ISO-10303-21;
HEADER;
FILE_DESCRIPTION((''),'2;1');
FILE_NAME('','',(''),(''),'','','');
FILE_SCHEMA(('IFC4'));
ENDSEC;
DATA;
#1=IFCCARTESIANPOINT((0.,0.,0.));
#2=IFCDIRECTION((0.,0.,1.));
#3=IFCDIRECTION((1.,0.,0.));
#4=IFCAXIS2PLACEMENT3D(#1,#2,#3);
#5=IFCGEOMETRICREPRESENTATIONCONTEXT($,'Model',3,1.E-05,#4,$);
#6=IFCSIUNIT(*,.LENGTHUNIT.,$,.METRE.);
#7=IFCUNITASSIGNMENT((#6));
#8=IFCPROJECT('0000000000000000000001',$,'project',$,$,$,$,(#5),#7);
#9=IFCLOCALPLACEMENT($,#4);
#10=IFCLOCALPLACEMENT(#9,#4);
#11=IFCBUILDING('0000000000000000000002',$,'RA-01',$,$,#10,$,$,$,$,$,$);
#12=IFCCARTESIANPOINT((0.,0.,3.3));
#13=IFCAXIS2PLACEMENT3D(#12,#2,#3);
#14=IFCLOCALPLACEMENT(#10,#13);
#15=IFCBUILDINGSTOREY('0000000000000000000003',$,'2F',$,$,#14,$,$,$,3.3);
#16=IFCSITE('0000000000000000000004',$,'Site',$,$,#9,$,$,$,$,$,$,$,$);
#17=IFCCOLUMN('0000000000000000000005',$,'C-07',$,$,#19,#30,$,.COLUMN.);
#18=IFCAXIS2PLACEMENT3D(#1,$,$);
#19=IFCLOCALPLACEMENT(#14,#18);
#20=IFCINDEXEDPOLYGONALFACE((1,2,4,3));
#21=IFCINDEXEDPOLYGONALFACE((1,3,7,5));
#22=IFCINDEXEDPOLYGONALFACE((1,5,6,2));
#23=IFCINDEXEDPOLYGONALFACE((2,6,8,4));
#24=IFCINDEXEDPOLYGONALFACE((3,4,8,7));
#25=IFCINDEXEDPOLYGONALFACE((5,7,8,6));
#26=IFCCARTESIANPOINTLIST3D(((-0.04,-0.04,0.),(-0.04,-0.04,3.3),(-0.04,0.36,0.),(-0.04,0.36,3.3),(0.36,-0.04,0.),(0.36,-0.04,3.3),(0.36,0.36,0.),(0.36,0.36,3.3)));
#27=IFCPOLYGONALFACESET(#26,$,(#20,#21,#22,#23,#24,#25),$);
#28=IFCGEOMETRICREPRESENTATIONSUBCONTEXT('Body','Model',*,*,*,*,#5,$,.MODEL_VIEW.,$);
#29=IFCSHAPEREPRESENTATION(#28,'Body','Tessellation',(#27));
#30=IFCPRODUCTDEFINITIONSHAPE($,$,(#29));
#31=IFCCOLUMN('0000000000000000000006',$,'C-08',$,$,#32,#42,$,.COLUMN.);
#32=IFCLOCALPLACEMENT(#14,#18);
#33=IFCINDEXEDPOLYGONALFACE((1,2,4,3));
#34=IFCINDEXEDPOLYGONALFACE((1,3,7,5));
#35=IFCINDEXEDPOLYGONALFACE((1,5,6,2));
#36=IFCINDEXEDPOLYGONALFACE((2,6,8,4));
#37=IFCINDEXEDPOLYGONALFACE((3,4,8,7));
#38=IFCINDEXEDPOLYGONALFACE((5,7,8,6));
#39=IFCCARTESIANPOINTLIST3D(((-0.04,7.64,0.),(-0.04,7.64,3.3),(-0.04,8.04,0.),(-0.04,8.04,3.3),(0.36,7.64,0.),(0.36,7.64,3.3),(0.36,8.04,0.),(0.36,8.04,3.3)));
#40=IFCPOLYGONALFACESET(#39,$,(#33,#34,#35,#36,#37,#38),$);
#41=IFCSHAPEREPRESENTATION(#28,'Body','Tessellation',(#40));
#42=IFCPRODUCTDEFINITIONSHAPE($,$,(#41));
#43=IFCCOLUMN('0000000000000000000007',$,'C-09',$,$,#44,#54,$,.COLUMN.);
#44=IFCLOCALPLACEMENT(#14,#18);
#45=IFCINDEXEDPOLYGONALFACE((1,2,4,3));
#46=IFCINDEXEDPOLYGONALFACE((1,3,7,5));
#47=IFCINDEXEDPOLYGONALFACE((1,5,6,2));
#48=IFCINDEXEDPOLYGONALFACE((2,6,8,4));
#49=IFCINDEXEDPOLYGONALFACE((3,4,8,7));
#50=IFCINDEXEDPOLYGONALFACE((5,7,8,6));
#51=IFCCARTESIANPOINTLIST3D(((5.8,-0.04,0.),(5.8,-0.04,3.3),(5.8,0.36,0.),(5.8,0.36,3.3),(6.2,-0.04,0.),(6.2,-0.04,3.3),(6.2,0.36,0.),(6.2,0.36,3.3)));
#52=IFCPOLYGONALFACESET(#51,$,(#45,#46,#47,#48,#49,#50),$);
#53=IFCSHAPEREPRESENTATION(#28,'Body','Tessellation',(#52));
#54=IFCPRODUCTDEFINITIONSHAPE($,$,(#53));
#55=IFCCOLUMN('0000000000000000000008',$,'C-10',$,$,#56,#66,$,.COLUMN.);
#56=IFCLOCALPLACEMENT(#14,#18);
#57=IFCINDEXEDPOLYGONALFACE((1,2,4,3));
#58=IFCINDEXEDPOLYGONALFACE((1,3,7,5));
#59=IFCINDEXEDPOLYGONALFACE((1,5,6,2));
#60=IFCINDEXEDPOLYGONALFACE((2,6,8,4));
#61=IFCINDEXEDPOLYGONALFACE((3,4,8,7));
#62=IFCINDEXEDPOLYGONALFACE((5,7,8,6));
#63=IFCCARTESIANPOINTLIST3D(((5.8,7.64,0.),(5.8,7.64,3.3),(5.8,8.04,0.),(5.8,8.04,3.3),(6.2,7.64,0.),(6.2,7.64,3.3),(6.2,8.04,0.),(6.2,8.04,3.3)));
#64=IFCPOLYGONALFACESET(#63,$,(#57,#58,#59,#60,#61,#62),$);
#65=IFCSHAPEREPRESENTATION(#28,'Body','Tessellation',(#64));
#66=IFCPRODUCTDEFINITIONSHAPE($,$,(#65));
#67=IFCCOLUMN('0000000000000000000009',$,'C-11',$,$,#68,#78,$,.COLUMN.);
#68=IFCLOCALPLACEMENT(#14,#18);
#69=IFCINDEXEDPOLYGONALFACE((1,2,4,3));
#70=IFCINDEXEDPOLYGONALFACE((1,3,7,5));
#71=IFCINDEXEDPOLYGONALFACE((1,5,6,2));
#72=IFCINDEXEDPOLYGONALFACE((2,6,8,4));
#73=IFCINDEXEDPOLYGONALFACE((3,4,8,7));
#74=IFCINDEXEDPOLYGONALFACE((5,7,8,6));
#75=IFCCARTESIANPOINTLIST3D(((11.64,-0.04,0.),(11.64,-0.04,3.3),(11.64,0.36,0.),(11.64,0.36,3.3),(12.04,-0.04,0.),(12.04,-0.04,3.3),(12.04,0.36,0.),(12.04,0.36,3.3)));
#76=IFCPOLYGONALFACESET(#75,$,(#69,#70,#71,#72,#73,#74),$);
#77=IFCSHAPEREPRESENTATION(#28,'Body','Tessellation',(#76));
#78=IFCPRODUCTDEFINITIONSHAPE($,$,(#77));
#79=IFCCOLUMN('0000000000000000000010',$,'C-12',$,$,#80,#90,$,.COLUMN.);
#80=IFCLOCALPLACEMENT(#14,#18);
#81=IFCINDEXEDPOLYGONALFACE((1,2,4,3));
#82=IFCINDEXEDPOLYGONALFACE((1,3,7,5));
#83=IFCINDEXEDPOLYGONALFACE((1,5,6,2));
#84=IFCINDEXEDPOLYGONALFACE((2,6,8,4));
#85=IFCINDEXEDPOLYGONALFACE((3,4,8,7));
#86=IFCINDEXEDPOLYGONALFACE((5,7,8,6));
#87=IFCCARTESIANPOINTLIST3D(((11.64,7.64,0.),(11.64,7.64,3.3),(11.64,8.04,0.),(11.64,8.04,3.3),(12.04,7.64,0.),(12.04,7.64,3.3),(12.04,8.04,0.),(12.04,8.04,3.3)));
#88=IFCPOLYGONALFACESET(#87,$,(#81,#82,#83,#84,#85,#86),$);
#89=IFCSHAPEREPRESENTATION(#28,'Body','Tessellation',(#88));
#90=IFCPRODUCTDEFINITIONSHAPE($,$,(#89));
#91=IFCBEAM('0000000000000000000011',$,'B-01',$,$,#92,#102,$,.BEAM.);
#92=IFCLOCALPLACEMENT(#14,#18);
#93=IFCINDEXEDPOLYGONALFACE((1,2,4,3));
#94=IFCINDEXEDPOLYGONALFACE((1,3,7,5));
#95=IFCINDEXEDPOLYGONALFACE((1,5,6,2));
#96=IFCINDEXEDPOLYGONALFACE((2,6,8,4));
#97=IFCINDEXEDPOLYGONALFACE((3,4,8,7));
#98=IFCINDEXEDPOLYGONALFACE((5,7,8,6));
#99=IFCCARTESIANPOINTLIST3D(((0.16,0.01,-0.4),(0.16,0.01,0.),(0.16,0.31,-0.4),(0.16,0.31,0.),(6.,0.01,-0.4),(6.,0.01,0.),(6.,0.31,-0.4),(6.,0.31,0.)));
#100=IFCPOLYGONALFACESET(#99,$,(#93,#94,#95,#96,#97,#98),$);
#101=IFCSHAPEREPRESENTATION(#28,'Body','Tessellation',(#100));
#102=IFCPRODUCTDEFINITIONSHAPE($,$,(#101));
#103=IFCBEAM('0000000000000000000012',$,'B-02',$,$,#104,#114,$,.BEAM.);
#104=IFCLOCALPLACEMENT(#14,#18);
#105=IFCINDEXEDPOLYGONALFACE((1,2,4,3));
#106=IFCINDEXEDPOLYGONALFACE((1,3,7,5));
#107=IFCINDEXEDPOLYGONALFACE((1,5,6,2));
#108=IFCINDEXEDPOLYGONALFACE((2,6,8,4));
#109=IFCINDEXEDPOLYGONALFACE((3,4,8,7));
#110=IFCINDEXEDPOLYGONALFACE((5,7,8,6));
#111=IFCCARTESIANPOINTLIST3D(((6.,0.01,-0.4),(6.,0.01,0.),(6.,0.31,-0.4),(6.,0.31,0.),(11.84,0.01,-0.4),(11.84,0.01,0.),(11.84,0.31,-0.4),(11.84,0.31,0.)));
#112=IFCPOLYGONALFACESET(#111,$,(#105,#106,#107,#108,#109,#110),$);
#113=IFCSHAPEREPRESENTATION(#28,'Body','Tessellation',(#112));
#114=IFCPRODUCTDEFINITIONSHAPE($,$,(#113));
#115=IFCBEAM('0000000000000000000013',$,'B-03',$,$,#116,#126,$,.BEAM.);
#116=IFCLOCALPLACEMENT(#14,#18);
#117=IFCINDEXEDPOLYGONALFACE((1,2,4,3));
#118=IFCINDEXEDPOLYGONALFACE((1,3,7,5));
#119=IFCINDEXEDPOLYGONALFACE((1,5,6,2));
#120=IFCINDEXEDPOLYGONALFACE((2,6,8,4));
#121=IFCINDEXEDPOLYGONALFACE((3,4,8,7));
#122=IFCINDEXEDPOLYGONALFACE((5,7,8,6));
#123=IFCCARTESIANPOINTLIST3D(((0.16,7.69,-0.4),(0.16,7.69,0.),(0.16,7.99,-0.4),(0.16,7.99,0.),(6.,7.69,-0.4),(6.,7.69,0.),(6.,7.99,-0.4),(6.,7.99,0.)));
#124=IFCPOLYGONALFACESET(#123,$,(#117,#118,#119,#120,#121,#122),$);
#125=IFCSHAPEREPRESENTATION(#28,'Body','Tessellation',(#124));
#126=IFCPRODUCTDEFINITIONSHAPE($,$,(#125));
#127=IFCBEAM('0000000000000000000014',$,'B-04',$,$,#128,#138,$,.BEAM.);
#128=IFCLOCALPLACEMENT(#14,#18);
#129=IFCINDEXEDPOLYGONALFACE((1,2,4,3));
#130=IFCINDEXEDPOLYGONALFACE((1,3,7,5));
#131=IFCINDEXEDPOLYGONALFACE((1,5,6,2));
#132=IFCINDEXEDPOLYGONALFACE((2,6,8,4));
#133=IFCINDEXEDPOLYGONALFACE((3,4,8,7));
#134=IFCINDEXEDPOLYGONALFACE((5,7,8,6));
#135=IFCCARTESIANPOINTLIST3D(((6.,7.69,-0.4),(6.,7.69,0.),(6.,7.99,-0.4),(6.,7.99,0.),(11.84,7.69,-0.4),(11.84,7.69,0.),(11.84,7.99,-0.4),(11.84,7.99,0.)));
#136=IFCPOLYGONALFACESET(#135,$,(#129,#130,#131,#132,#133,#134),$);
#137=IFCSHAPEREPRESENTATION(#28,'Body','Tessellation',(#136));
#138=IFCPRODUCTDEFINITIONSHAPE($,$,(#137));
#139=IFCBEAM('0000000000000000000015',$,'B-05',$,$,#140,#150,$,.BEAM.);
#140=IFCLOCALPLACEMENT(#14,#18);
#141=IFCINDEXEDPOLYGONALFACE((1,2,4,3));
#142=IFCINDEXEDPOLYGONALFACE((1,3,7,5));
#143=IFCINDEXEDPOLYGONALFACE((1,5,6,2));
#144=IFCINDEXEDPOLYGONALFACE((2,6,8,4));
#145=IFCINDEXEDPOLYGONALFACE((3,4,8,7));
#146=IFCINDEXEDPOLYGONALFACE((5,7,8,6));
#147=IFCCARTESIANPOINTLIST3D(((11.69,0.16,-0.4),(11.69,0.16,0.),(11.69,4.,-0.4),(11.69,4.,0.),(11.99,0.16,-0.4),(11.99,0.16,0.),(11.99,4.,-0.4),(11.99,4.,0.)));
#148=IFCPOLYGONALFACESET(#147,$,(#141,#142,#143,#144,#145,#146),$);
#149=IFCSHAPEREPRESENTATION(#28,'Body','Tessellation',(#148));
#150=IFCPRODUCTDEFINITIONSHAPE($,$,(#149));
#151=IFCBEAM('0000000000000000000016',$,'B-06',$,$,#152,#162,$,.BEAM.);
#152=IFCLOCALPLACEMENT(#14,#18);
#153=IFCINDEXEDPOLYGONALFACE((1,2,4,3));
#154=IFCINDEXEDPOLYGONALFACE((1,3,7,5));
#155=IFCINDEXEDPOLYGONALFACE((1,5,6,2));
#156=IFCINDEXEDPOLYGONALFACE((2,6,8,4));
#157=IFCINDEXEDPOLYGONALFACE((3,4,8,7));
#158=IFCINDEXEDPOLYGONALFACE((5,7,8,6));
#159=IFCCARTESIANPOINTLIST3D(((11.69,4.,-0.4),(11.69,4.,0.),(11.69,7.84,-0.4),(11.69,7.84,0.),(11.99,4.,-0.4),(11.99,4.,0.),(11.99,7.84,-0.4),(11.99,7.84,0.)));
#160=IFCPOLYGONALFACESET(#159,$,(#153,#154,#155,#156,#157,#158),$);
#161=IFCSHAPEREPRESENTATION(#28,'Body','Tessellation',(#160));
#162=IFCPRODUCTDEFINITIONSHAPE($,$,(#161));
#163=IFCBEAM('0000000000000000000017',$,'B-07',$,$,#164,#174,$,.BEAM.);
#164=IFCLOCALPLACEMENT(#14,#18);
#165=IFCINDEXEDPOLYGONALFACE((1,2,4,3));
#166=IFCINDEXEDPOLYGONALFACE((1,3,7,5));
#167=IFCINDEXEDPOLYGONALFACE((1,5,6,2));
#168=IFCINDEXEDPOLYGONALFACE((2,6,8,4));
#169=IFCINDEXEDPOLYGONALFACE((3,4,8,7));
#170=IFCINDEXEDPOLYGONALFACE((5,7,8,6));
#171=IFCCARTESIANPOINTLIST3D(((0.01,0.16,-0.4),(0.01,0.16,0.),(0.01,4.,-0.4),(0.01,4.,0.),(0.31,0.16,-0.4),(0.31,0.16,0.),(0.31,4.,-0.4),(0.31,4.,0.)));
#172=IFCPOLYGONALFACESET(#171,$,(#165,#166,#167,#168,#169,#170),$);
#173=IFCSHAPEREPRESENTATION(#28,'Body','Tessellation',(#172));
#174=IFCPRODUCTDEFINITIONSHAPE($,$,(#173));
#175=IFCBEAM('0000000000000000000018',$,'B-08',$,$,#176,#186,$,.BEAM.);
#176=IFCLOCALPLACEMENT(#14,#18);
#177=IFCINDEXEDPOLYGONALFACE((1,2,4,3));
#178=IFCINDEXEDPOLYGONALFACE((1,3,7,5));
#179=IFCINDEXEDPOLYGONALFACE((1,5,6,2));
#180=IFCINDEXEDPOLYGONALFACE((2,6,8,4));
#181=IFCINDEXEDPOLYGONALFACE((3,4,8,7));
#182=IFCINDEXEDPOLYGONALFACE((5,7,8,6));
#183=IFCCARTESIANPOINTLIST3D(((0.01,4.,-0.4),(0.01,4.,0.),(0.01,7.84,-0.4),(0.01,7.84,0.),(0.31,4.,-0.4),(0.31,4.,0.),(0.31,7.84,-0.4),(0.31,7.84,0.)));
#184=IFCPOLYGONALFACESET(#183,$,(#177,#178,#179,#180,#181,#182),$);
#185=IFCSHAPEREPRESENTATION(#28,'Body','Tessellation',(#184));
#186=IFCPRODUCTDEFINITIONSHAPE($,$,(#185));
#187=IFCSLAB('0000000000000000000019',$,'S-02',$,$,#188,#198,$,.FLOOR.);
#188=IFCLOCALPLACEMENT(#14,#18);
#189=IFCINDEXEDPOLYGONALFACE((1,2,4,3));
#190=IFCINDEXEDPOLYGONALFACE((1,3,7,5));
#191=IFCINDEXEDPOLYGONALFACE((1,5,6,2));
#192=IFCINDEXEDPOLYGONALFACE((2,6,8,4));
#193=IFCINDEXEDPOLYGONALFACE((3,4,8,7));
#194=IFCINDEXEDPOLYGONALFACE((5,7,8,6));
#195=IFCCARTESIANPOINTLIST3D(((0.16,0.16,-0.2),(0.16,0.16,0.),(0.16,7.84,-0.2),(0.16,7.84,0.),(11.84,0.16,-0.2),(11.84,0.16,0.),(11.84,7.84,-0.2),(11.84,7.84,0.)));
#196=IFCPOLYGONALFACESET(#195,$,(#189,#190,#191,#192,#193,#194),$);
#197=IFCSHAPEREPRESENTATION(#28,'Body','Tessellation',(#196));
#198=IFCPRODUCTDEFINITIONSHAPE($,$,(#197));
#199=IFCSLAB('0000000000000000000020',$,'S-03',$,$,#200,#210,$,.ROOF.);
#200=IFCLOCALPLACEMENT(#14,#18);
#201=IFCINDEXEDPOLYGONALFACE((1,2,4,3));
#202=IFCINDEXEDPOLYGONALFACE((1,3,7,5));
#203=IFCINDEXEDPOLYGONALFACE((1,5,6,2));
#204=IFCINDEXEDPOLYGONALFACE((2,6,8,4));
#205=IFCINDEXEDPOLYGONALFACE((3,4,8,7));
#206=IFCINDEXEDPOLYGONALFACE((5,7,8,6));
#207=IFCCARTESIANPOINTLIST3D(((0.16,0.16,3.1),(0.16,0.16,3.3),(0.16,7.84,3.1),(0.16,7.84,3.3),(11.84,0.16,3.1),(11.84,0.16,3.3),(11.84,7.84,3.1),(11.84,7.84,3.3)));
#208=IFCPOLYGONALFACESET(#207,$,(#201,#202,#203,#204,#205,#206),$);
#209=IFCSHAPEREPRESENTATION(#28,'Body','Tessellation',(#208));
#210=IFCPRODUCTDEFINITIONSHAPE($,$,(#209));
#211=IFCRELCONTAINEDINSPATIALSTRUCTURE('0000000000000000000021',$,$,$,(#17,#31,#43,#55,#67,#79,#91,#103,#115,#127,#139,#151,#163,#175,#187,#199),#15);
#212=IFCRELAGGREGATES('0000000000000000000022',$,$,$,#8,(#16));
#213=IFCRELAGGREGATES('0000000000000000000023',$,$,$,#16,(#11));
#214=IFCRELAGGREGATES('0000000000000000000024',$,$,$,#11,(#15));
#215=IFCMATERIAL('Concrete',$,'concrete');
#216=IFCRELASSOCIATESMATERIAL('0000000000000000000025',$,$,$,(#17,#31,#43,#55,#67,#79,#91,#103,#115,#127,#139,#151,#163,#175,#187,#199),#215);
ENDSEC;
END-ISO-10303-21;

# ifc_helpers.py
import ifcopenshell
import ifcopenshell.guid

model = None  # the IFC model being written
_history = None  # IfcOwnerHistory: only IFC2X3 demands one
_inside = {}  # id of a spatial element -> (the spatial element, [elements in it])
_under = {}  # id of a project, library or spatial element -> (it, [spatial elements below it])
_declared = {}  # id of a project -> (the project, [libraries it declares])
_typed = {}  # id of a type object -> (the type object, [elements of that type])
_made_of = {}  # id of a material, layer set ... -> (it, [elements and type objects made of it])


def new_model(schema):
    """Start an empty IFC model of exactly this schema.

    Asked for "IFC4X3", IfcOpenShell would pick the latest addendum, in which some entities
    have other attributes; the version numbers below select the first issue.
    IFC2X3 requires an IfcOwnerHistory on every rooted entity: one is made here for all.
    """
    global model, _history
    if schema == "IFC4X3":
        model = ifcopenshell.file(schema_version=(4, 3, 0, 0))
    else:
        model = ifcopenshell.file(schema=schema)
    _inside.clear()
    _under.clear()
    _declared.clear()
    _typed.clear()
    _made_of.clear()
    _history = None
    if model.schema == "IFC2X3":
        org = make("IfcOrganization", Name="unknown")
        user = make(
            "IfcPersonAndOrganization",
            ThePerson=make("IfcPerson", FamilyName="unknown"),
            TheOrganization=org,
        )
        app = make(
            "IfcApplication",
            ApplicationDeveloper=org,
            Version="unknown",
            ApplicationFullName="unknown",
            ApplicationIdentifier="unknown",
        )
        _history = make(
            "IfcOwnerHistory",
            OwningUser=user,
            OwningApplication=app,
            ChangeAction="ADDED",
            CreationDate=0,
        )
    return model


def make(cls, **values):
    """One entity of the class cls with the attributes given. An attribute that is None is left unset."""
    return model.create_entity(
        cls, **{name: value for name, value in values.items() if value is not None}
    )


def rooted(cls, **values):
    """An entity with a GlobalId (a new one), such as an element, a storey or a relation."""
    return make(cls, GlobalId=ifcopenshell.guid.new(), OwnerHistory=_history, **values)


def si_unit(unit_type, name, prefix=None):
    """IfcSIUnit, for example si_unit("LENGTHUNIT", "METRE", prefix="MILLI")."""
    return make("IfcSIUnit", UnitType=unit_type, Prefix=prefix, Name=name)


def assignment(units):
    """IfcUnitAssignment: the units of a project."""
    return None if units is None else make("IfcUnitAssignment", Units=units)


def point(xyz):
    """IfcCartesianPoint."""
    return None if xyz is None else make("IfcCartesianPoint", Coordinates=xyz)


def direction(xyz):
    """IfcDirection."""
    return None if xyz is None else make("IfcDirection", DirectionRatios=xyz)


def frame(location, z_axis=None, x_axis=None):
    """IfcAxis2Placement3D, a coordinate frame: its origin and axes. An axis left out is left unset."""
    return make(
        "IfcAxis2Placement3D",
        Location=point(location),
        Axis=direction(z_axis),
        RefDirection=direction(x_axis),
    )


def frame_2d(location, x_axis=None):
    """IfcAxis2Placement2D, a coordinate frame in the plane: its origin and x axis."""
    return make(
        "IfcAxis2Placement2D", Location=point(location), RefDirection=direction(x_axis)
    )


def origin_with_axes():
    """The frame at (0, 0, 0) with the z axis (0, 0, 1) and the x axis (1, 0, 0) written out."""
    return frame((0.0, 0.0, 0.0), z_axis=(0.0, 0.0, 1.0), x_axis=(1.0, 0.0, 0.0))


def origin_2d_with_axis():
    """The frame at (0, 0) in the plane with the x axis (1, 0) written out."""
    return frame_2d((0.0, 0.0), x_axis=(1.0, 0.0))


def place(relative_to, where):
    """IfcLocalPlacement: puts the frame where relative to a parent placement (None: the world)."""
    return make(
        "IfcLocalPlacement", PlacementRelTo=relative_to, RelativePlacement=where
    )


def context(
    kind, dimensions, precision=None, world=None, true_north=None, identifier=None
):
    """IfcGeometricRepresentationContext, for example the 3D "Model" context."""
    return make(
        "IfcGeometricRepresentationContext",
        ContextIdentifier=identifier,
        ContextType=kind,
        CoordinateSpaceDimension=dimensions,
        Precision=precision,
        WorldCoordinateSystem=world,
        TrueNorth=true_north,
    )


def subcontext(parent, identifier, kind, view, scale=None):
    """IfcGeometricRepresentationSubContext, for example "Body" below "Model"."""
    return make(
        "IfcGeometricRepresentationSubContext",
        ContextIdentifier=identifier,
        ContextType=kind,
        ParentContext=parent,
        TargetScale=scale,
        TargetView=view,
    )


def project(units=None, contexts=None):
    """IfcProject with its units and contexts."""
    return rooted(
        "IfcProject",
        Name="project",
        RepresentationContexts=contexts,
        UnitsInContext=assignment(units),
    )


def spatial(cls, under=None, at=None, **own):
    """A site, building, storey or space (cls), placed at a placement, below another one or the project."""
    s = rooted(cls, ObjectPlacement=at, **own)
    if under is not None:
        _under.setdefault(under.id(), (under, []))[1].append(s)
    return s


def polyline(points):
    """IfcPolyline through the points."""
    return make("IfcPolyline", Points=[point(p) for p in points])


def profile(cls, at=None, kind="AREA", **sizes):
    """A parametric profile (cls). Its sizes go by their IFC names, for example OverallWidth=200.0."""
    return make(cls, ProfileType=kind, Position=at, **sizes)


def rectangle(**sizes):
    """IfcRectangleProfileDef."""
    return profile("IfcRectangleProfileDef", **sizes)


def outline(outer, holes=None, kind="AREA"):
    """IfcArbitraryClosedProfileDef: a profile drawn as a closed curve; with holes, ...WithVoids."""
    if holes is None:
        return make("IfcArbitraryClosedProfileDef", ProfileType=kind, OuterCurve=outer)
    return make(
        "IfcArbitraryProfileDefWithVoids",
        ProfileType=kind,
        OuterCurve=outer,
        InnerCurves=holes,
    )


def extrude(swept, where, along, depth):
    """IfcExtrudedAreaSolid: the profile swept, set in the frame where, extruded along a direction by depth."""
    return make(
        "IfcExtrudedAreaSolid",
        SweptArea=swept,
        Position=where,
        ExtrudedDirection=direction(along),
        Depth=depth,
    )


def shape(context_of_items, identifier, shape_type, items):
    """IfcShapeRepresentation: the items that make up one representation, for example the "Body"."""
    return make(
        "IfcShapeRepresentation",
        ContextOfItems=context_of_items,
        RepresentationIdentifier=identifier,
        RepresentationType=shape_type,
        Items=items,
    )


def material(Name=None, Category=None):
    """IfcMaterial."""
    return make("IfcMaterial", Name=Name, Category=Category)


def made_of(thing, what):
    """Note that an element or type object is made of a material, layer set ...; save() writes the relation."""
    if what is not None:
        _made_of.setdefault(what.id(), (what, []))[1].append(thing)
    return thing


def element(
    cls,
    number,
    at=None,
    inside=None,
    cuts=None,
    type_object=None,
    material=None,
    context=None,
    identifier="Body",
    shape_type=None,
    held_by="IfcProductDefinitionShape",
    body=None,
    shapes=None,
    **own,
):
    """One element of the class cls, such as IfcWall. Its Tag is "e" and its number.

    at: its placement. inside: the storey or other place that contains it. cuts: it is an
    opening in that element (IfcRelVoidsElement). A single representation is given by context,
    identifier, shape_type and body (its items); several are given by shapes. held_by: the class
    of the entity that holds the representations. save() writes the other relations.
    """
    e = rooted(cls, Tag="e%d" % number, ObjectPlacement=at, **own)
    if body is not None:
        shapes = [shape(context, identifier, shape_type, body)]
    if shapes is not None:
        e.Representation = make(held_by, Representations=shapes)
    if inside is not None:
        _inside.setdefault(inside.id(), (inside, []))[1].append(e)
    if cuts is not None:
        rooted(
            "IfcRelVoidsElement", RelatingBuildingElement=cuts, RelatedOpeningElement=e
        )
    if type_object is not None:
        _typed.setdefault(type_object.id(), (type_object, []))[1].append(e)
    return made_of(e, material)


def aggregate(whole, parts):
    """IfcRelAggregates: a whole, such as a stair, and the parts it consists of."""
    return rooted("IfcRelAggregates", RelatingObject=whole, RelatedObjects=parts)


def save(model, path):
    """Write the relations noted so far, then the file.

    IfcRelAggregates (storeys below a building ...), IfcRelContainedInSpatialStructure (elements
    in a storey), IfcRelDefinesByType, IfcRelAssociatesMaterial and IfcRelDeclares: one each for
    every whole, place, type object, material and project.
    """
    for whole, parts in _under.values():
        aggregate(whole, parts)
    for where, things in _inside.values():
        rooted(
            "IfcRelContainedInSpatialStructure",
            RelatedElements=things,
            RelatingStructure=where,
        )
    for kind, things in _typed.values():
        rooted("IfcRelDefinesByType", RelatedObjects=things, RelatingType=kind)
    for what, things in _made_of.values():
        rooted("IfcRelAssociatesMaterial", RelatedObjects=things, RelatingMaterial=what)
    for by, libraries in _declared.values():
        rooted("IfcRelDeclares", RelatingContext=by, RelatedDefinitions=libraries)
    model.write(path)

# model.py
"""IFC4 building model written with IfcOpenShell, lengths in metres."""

from ifc_helpers import new_model, si_unit, frame, origin_with_axes, origin_2d_with_axis, place, context, subcontext, project, spatial, polyline, rectangle, outline, extrude, material, element, save


model = new_model("IFC4")

# Units and contexts
model_context = context("Model", 3, precision=1e-05, world=origin_with_axes())
body_context = subcontext(model_context, "Body", "Model", "MODEL_VIEW")
ifc_project = project(units=[si_unit("LENGTHUNIT", "METRE")], contexts=[model_context])

# Site, building, storey
site_placement = place(None, origin_with_axes())
site = spatial("IfcSite", under=ifc_project, at=site_placement, Name="Site")
building_placement = place(site_placement, origin_with_axes())
building = spatial("IfcBuilding", under=site, at=building_placement, Name="RA-01")
storey_placement = place(building_placement, frame((0.0, 0.0, 3.3), z_axis=(0.0, 0.0, 1.0), x_axis=(1.0, 0.0, 0.0)))
storey = spatial("IfcBuildingStorey", under=building, at=storey_placement, Name="2F", Elevation=3.3)

# Columns
ifc_material_1 = material(Name="Concrete", Category="concrete")
for number, where, z_axis, x_axis, name in (
    (1, (0.16, 0.16, 0.0), (0.0, 0.0, 1.0), (1.0, 0.0, 0.0), "C-07"),
    (2, (0.16, 7.84, 0.0), (0.0, 0.0, 1.0), (1.0, 0.0, 0.0), "C-08"),
    (3, (6.0, 0.16, 0.0), (0.0, 0.0, 1.0), (1.0, 0.0, 0.0), "C-09"),
    (4, (6.0, 7.84, 0.0), (0.0, 0.0, 1.0), (1.0, 0.0, 0.0), "C-10"),
    (5, (11.84, 0.16, 0.0), (0.0, 0.0, 1.0), (1.0, 0.0, 0.0), "C-11"),
    (6, (11.84, 7.84, 0.0), (0.0, 0.0, 1.0), (1.0, 0.0, 0.0), "C-12"),
):
    element("IfcColumn", number, at=place(storey_placement, frame(where, z_axis=z_axis, x_axis=x_axis)), inside=storey, material=ifc_material_1, Name=name, PredefinedType="COLUMN", context=body_context, shape_type="SweptSolid", body=[
        extrude(rectangle(XDim=0.4, YDim=0.4, at=origin_2d_with_axis()), origin_with_axes(), (0.0, 0.0, 1.0), 3.3),
    ])

# Beams
for number, where, z_axis, x_axis, name in (
    (7, (0.16, 0.16, -0.2), (1.0, 0.0, 0.0), (0.0, 1.0, 0.0), "B-01"),
    (8, (6.0, 0.16, -0.2), (1.0, 0.0, 0.0), (0.0, 1.0, 0.0), "B-02"),
    (9, (0.16, 7.84, -0.2), (1.0, 0.0, 0.0), (0.0, 1.0, 0.0), "B-03"),
    (10, (6.0, 7.84, -0.2), (1.0, 0.0, 0.0), (0.0, 1.0, 0.0), "B-04"),
):
    element("IfcBeam", number, at=place(storey_placement, frame(where, z_axis=z_axis, x_axis=x_axis)), inside=storey, material=ifc_material_1, Name=name, PredefinedType="BEAM", context=body_context, shape_type="SweptSolid", body=[
        extrude(rectangle(XDim=0.3, YDim=0.4, at=origin_2d_with_axis()), origin_with_axes(), (0.0, 0.0, 1.0), 5.84),
    ])
for number, where, z_axis, x_axis, name in (
    (11, (11.84, 0.16, -0.2), (0.0, 1.0, 0.0), (-1.0, 0.0, 0.0), "B-05"),
    (12, (11.84, 4.0, -0.2), (0.0, 1.0, 0.0), (-1.0, 0.0, 0.0), "B-06"),
    (13, (0.16, 0.16, -0.2), (0.0, 1.0, 0.0), (-1.0, 0.0, 0.0), "B-07"),
    (14, (0.16, 4.0, -0.2), (0.0, 1.0, 0.0), (-1.0, 0.0, 0.0), "B-08"),
):
    element("IfcBeam", number, at=place(storey_placement, frame(where, z_axis=z_axis, x_axis=x_axis)), inside=storey, material=ifc_material_1, Name=name, PredefinedType="BEAM", context=body_context, shape_type="SweptSolid", body=[
        extrude(rectangle(XDim=0.3, YDim=0.4, at=origin_2d_with_axis()), origin_with_axes(), (0.0, 0.0, 1.0), 3.84),
    ])

# Slabs
slab_1_placement = place(storey_placement, frame((0.0, 0.0, -0.2), z_axis=(0.0, 0.0, 1.0), x_axis=(1.0, 0.0, 0.0)))
element("IfcSlab", 15, at=slab_1_placement, inside=storey, material=ifc_material_1, Name="S-02", PredefinedType="FLOOR", context=body_context, shape_type="SweptSolid", body=[
    extrude(outline(polyline([(0.16, 0.16), (11.84, 0.16), (11.84, 7.84), (0.16, 7.84), (0.16, 0.16)])), origin_with_axes(), (0.0, 0.0, 1.0), 0.2),
])
slab_2_placement = place(storey_placement, frame((0.0, 0.0, 3.1), z_axis=(0.0, 0.0, 1.0), x_axis=(1.0, 0.0, 0.0)))
element("IfcSlab", 16, at=slab_2_placement, inside=storey, material=ifc_material_1, Name="S-03", PredefinedType="ROOF", context=body_context, shape_type="SweptSolid", body=[
    extrude(outline(polyline([(0.16, 0.16), (11.84, 0.16), (11.84, 7.84), (0.16, 7.84), (0.16, 0.16)])), origin_with_axes(), (0.0, 0.0, 1.0), 0.2),
])

save(model, "model.ifc")
